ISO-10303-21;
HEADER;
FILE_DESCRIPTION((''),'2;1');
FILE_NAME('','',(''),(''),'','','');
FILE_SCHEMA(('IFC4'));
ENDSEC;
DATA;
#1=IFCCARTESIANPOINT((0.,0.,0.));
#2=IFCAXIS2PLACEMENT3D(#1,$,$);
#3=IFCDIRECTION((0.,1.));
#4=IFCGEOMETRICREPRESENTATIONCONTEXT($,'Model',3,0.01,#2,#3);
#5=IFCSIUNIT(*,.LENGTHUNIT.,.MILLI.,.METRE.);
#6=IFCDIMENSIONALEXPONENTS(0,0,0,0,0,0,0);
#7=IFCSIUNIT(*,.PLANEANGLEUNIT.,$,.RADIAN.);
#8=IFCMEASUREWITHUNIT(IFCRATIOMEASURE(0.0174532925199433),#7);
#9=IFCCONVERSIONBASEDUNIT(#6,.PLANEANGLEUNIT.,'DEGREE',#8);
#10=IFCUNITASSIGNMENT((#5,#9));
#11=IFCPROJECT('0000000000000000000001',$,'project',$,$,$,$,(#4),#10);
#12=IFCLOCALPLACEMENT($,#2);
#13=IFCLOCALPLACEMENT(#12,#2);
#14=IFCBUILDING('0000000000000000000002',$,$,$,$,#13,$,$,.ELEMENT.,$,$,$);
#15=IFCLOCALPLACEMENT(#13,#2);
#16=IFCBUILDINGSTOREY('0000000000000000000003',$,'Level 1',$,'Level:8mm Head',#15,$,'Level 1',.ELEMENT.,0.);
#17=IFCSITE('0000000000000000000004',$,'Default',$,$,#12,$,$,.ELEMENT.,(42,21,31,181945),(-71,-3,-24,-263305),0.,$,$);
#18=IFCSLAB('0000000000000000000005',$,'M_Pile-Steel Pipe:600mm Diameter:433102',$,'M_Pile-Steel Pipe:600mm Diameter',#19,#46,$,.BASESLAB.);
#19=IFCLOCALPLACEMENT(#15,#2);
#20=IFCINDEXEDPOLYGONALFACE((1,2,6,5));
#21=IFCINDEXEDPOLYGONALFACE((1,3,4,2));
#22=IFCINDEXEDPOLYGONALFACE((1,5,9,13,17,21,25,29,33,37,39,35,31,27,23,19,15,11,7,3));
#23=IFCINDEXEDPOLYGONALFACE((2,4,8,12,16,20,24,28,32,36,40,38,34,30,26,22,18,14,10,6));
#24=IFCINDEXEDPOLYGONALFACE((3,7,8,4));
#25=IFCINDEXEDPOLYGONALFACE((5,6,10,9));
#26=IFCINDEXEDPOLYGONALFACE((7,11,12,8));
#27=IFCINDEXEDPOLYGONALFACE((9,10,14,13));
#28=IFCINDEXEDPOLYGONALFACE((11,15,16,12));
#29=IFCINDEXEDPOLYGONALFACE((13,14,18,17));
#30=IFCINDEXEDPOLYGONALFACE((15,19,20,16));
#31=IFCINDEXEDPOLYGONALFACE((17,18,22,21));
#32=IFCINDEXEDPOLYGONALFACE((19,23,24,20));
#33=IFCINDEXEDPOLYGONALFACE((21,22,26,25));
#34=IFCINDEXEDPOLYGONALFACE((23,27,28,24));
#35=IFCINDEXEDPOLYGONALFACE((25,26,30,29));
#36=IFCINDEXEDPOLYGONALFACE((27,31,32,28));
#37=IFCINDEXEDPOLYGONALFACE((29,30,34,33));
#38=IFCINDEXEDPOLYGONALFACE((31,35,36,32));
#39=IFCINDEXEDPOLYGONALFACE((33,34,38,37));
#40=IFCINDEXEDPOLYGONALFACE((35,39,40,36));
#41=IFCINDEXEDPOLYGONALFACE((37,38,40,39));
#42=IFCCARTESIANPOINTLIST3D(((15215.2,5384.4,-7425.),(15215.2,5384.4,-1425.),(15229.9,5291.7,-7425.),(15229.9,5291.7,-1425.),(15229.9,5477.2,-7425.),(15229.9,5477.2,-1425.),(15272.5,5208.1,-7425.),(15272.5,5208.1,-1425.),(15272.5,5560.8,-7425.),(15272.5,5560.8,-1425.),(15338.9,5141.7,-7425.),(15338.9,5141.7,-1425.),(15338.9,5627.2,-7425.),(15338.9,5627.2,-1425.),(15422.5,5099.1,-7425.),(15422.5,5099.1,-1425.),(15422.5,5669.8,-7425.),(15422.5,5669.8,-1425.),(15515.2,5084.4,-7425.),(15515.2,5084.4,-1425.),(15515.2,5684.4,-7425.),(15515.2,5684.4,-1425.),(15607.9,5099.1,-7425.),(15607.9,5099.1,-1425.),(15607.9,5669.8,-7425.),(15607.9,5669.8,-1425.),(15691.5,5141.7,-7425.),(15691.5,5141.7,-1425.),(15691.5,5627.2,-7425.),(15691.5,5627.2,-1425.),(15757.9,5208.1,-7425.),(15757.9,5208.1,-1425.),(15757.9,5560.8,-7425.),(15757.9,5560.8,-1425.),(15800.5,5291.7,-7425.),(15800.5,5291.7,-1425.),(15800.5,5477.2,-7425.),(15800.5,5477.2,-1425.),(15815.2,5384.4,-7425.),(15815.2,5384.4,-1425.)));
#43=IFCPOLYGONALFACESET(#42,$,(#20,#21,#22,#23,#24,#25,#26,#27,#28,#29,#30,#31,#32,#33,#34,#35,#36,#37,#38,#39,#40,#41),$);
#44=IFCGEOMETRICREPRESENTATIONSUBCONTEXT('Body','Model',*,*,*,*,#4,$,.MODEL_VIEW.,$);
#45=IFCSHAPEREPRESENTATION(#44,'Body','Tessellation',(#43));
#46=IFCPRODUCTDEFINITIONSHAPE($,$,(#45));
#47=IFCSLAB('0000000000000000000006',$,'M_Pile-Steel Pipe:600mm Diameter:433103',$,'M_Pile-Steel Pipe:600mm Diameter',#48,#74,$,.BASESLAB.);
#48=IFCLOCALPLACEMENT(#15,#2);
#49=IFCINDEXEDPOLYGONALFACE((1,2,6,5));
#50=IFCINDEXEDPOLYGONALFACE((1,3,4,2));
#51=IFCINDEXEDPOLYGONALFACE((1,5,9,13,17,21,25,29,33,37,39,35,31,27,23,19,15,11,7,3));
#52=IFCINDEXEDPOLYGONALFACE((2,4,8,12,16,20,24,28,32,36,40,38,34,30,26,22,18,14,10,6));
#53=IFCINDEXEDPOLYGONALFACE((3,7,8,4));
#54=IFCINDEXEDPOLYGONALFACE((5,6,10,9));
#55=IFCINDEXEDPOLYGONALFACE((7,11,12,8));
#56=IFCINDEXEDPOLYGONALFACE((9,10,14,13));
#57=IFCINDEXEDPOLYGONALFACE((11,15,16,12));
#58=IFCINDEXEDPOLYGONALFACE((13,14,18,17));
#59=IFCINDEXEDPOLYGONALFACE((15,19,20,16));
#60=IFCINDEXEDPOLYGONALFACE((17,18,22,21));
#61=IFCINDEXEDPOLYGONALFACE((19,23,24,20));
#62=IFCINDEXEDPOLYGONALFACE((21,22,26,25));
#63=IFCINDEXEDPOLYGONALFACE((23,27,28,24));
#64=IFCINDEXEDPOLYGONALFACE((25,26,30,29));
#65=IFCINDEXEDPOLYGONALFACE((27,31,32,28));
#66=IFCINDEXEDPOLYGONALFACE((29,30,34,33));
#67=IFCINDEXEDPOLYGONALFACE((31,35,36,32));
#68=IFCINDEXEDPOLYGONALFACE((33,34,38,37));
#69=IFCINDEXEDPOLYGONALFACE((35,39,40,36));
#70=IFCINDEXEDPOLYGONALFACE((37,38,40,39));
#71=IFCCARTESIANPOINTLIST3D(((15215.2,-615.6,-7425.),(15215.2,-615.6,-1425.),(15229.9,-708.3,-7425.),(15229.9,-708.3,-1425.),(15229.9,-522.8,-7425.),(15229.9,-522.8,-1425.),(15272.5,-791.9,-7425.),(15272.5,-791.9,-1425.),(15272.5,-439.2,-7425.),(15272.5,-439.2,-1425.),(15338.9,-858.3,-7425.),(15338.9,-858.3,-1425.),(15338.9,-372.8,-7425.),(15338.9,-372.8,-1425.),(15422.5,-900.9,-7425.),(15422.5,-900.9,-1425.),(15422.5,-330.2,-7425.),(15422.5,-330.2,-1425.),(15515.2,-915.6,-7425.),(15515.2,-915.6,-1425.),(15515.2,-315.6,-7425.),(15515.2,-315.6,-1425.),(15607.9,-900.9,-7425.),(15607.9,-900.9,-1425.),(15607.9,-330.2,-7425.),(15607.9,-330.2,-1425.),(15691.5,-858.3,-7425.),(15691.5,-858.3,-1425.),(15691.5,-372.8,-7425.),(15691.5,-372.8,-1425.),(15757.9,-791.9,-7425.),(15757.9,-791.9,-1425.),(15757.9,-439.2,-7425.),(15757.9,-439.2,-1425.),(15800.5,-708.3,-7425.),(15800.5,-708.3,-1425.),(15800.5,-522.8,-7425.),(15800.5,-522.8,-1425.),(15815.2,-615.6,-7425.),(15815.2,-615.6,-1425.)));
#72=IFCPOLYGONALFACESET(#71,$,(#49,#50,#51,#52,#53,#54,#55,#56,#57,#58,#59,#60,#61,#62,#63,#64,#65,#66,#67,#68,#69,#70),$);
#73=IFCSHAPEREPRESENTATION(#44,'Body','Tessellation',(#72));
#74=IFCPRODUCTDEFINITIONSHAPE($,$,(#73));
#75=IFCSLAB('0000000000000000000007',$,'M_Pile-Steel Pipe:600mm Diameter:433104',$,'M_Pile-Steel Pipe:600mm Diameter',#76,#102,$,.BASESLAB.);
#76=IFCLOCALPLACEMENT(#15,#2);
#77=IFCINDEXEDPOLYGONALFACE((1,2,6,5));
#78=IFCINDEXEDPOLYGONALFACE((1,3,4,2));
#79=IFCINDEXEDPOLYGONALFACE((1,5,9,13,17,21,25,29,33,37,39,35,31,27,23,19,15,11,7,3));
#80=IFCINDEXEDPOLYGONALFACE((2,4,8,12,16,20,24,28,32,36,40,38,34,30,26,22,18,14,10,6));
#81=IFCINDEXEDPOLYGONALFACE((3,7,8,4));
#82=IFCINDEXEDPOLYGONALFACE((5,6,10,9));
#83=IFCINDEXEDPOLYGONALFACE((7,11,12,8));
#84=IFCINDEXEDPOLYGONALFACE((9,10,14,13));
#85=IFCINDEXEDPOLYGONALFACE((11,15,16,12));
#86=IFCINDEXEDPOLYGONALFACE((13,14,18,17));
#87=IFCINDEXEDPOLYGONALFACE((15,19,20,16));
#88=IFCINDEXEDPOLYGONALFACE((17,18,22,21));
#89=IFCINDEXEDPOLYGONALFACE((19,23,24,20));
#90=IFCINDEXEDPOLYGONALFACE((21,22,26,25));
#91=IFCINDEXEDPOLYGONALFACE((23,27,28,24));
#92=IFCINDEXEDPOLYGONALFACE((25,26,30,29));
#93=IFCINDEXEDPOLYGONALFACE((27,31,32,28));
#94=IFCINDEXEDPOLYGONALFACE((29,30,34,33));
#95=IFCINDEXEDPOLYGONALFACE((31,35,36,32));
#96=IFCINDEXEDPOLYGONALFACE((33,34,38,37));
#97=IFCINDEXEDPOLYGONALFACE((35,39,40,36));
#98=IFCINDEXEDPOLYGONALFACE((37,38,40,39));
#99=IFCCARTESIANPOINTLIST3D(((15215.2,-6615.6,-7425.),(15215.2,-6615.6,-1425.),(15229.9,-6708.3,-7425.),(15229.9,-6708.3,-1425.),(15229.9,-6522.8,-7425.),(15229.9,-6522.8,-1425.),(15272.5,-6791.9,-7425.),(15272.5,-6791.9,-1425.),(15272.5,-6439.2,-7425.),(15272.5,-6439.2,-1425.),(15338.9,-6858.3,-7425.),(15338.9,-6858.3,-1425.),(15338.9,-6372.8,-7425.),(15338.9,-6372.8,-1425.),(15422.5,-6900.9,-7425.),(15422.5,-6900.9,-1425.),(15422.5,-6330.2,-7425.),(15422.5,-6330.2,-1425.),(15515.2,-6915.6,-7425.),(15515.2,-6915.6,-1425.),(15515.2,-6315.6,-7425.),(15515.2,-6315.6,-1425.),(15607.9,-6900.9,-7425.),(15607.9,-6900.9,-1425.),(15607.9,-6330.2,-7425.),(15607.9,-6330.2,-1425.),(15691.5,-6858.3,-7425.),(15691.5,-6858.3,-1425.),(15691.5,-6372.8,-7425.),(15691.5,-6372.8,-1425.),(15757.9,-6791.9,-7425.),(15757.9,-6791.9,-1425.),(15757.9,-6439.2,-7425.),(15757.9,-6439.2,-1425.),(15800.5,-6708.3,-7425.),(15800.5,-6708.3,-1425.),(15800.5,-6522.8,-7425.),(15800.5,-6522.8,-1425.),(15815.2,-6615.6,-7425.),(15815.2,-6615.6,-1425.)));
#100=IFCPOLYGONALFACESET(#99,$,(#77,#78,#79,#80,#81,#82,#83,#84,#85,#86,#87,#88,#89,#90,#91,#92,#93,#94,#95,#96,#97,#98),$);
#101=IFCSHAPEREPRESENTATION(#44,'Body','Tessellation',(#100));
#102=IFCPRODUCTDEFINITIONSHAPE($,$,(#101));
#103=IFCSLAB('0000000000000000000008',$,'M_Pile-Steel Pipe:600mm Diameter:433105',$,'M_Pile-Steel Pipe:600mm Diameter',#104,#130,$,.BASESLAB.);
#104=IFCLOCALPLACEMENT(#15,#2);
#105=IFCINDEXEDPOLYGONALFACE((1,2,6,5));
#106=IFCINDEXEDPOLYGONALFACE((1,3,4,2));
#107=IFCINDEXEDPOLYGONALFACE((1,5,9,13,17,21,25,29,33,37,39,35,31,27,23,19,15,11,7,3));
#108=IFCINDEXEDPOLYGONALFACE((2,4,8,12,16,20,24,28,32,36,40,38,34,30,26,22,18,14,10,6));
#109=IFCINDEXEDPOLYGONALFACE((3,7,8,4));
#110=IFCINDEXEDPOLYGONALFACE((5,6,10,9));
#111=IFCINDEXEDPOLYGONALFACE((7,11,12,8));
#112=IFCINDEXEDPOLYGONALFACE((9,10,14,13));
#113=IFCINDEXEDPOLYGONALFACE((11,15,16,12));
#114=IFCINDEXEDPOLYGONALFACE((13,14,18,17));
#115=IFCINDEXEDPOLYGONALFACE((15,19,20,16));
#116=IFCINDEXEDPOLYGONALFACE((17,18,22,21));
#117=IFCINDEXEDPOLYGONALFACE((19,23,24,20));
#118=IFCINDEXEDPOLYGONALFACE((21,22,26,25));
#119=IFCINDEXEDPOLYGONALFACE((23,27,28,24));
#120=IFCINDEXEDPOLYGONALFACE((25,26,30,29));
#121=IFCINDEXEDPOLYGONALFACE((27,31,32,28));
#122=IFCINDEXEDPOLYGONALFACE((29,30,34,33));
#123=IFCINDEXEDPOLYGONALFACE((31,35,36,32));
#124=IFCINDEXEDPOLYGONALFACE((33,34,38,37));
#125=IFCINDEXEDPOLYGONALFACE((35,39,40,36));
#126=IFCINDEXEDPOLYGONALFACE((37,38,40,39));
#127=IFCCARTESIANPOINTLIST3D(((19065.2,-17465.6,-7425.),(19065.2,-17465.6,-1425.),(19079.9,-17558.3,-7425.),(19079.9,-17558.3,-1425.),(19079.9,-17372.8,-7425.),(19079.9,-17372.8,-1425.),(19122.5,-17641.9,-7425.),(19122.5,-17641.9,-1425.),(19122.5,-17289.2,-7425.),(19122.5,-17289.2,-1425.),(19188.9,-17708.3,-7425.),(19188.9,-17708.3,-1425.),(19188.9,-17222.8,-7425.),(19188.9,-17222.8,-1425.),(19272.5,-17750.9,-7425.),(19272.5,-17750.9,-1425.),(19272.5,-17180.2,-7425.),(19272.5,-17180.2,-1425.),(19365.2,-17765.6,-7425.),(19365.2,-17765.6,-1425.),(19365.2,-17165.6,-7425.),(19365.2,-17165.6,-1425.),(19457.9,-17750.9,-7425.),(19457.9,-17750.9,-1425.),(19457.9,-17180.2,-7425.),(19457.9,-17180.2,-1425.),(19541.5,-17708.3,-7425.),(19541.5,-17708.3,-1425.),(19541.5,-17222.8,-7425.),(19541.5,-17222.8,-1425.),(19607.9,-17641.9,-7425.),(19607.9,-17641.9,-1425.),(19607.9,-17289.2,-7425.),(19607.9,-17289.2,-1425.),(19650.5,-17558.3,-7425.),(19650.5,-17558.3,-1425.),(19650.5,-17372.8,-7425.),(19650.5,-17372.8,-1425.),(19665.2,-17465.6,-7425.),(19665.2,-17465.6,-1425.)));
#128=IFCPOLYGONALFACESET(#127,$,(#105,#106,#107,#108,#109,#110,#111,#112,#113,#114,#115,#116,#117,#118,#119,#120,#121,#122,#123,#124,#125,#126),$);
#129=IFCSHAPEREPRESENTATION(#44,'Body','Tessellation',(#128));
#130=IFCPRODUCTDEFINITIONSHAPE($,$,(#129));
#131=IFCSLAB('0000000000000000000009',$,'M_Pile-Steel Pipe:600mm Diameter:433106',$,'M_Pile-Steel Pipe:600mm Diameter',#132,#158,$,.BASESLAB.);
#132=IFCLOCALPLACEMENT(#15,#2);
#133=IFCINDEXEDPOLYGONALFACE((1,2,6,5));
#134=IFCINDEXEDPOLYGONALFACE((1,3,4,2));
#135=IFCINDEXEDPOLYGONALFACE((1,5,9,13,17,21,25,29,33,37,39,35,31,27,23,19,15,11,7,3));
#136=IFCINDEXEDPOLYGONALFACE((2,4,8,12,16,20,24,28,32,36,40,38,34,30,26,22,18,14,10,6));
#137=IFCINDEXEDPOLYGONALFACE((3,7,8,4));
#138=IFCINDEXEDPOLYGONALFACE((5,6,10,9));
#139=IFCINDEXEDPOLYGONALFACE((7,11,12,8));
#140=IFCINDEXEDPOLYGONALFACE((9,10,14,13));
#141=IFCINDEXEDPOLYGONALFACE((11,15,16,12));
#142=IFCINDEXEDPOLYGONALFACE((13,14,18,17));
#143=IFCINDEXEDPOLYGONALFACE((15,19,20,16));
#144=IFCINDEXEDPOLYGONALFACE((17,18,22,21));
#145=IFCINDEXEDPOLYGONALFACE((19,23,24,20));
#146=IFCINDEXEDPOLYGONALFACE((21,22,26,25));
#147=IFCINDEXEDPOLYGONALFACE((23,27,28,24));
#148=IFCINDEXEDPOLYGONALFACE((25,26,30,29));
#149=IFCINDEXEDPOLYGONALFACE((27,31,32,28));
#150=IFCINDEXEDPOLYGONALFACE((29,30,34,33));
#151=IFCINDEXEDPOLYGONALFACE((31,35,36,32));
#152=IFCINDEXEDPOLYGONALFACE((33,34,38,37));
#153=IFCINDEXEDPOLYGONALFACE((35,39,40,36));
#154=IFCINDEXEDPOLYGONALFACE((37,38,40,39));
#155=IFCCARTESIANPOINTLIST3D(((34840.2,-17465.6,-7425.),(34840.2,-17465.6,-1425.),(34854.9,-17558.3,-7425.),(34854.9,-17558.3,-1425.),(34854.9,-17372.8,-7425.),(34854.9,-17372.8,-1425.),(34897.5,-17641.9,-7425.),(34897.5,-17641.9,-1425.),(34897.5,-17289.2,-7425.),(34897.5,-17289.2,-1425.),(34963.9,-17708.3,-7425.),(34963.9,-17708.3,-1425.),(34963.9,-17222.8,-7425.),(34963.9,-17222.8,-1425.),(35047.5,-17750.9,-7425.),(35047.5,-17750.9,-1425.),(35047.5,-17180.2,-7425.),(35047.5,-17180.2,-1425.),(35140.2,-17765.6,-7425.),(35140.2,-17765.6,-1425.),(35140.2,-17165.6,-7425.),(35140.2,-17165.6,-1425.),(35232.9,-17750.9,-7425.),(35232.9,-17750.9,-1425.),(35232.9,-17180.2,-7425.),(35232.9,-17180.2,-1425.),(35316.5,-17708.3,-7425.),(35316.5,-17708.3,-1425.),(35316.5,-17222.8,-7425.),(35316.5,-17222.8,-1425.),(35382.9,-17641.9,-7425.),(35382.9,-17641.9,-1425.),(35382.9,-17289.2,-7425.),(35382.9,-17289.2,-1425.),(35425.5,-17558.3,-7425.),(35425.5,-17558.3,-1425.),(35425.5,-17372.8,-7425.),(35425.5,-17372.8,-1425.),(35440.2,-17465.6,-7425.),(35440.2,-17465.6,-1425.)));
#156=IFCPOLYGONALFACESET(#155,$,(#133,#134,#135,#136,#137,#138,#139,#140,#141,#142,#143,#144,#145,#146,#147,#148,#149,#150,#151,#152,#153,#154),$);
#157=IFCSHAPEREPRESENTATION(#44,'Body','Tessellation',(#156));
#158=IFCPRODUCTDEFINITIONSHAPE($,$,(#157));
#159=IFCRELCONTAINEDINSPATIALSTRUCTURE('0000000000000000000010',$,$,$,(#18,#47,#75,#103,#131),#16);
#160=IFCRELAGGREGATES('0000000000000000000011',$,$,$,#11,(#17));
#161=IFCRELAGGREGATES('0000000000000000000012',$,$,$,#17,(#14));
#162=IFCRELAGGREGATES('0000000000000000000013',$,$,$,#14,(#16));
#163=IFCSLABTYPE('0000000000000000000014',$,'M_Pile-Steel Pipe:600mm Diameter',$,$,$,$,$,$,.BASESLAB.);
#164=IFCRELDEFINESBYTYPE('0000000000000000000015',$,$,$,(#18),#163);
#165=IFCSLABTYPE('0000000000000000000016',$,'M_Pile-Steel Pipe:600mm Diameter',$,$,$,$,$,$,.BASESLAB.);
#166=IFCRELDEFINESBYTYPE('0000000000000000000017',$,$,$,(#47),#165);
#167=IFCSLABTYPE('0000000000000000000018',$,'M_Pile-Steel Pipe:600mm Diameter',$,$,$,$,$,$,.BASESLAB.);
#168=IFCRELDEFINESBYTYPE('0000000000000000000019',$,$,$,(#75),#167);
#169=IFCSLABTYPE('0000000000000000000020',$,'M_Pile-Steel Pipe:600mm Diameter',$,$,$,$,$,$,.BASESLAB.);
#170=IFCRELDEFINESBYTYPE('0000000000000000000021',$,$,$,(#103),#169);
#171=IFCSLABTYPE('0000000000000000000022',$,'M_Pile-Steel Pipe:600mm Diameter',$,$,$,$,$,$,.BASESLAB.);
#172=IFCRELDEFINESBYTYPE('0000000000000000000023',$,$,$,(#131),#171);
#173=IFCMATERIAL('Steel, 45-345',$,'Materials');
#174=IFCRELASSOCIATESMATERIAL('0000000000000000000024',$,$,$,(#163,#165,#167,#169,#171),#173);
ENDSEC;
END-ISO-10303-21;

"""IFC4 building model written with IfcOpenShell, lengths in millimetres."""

from ifc_helpers import new_model, entity, si_unit, converted_unit, direction, frame, origin, place, context, subcontext, project, spatial, indexed_curve, outline, extrude, material, type_object, element, save


model = new_model("IFC4")

# Units and contexts
model_context = context("Model", 3, precision=0.01, world=origin(), true_north=direction((0.0, 1.0)))
body_context = subcontext(model_context, "Body", "Model", "MODEL_VIEW")
ifc_project = project(units=[si_unit("LENGTHUNIT", "METRE", prefix="MILLI"), converted_unit("PLANEANGLEUNIT", "DEGREE", entity("IfcRatioMeasure", 0.0174532925199433), si_unit("PLANEANGLEUNIT", "RADIAN"), dimensions=[0, 0, 0, 0, 0, 0, 0])], contexts=[model_context])

# Site, building, storey
site_placement = place(None, origin())
site = spatial("IfcSite", under=ifc_project, at=site_placement, Name="Default", CompositionType="ELEMENT", RefLatitude=(42, 21, 31, 181945), RefLongitude=(-71, -3, -24, -263305), RefElevation=0.0)
building_placement = place(site_placement, origin())
building = spatial("IfcBuilding", under=site, at=building_placement, CompositionType="ELEMENT")
storey_placement = place(building_placement, origin())
storey = spatial("IfcBuildingStorey", under=building, at=storey_placement, Name="Level 1", ObjectType="Level:8mm Head", LongName="Level 1", CompositionType="ELEMENT", Elevation=0.0)

# Slabs
ifc_material_1 = material(Name="Steel, 45-345", Category="Materials")
slab_type_1 = type_object("IfcSlabType", Name="M_Pile-Steel Pipe:600mm Diameter", PredefinedType="BASESLAB", material=ifc_material_1)
slab_1_placement = place(building_placement, origin())
element("IfcSlab", 1, at=slab_1_placement, inside=storey, type_object=slab_type_1, Name="M_Pile-Steel Pipe:600mm Diameter:433102", ObjectType="M_Pile-Steel Pipe:600mm Diameter", PredefinedType="BASESLAB", context=body_context, shape_type="SweptSolid", body=[
    extrude(outline(indexed_curve([(300.0, 0.0), (285.3, 92.7), (242.7, 176.3), (176.3, 242.7), (92.7, 285.3), (0.0, 300.0), (-92.7, 285.3), (-176.3, 242.7), (-242.7, 176.3), (-285.3, 92.7), (-300.0, 0.0), (-285.3, -92.7), (-242.7, -176.3), (-176.3, -242.7), (-92.7, -285.3), (0.0, -300.0), (92.7, -285.3), (176.3, -242.7), (242.7, -176.3), (285.3, -92.7), (300.0, 0.0)], self_intersect=False)), frame((15515.2, 5384.4, -7425.0)), (0.0, 0.0, 1.0), 6000.0),
])
slab_type_2 = type_object("IfcSlabType", Name="M_Pile-Steel Pipe:600mm Diameter", PredefinedType="BASESLAB", material=ifc_material_1)
slab_2_placement = place(building_placement, origin())
element("IfcSlab", 2, at=slab_2_placement, inside=storey, type_object=slab_type_2, Name="M_Pile-Steel Pipe:600mm Diameter:433103", ObjectType="M_Pile-Steel Pipe:600mm Diameter", PredefinedType="BASESLAB", context=body_context, shape_type="SweptSolid", body=[
    extrude(outline(indexed_curve([(300.0, 0.0), (285.3, 92.7), (242.7, 176.3), (176.3, 242.7), (92.7, 285.3), (0.0, 300.0), (-92.7, 285.3), (-176.3, 242.7), (-242.7, 176.3), (-285.3, 92.7), (-300.0, 0.0), (-285.3, -92.7), (-242.7, -176.3), (-176.3, -242.7), (-92.7, -285.3), (0.0, -300.0), (92.7, -285.3), (176.3, -242.7), (242.7, -176.3), (285.3, -92.7), (300.0, 0.0)], self_intersect=False)), frame((15515.2, -615.6, -7425.0)), (0.0, 0.0, 1.0), 6000.0),
])
slab_type_3 = type_object("IfcSlabType", Name="M_Pile-Steel Pipe:600mm Diameter", PredefinedType="BASESLAB", material=ifc_material_1)
slab_3_placement = place(building_placement, origin())
element("IfcSlab", 3, at=slab_3_placement, inside=storey, type_object=slab_type_3, Name="M_Pile-Steel Pipe:600mm Diameter:433104", ObjectType="M_Pile-Steel Pipe:600mm Diameter", PredefinedType="BASESLAB", context=body_context, shape_type="SweptSolid", body=[
    extrude(outline(indexed_curve([(300.0, 0.0), (285.3, 92.7), (242.7, 176.3), (176.3, 242.7), (92.7, 285.3), (0.0, 300.0), (-92.7, 285.3), (-176.3, 242.7), (-242.7, 176.3), (-285.3, 92.7), (-300.0, 0.0), (-285.3, -92.7), (-242.7, -176.3), (-176.3, -242.7), (-92.7, -285.3), (0.0, -300.0), (92.7, -285.3), (176.3, -242.7), (242.7, -176.3), (285.3, -92.7), (300.0, 0.0)], self_intersect=False)), frame((15515.2, -6615.6, -7425.0)), (0.0, 0.0, 1.0), 6000.0),
])
slab_type_4 = type_object("IfcSlabType", Name="M_Pile-Steel Pipe:600mm Diameter", PredefinedType="BASESLAB", material=ifc_material_1)
slab_4_placement = place(building_placement, origin())
element("IfcSlab", 4, at=slab_4_placement, inside=storey, type_object=slab_type_4, Name="M_Pile-Steel Pipe:600mm Diameter:433105", ObjectType="M_Pile-Steel Pipe:600mm Diameter", PredefinedType="BASESLAB", context=body_context, shape_type="SweptSolid", body=[
    extrude(outline(indexed_curve([(300.0, 0.0), (285.3, 92.7), (242.7, 176.3), (176.3, 242.7), (92.7, 285.3), (0.0, 300.0), (-92.7, 285.3), (-176.3, 242.7), (-242.7, 176.3), (-285.3, 92.7), (-300.0, 0.0), (-285.3, -92.7), (-242.7, -176.3), (-176.3, -242.7), (-92.7, -285.3), (0.0, -300.0), (92.7, -285.3), (176.3, -242.7), (242.7, -176.3), (285.3, -92.7), (300.0, 0.0)], self_intersect=False)), frame((19365.2, -17465.6, -7425.0)), (0.0, 0.0, 1.0), 6000.0),
])
slab_type_5 = type_object("IfcSlabType", Name="M_Pile-Steel Pipe:600mm Diameter", PredefinedType="BASESLAB", material=ifc_material_1)
slab_5_placement = place(building_placement, origin())
element("IfcSlab", 5, at=slab_5_placement, inside=storey, type_object=slab_type_5, Name="M_Pile-Steel Pipe:600mm Diameter:433106", ObjectType="M_Pile-Steel Pipe:600mm Diameter", PredefinedType="BASESLAB", context=body_context, shape_type="SweptSolid", body=[
    extrude(outline(indexed_curve([(300.0, 0.0), (285.3, 92.7), (242.7, 176.3), (176.3, 242.7), (92.7, 285.3), (0.0, 300.0), (-92.7, 285.3), (-176.3, 242.7), (-242.7, 176.3), (-285.3, 92.7), (-300.0, 0.0), (-285.3, -92.7), (-242.7, -176.3), (-176.3, -242.7), (-92.7, -285.3), (0.0, -300.0), (92.7, -285.3), (176.3, -242.7), (242.7, -176.3), (285.3, -92.7), (300.0, 0.0)], self_intersect=False)), frame((35140.2, -17465.6, -7425.0)), (0.0, 0.0, 1.0), 6000.0),
])

save(model, "model.ifc")
